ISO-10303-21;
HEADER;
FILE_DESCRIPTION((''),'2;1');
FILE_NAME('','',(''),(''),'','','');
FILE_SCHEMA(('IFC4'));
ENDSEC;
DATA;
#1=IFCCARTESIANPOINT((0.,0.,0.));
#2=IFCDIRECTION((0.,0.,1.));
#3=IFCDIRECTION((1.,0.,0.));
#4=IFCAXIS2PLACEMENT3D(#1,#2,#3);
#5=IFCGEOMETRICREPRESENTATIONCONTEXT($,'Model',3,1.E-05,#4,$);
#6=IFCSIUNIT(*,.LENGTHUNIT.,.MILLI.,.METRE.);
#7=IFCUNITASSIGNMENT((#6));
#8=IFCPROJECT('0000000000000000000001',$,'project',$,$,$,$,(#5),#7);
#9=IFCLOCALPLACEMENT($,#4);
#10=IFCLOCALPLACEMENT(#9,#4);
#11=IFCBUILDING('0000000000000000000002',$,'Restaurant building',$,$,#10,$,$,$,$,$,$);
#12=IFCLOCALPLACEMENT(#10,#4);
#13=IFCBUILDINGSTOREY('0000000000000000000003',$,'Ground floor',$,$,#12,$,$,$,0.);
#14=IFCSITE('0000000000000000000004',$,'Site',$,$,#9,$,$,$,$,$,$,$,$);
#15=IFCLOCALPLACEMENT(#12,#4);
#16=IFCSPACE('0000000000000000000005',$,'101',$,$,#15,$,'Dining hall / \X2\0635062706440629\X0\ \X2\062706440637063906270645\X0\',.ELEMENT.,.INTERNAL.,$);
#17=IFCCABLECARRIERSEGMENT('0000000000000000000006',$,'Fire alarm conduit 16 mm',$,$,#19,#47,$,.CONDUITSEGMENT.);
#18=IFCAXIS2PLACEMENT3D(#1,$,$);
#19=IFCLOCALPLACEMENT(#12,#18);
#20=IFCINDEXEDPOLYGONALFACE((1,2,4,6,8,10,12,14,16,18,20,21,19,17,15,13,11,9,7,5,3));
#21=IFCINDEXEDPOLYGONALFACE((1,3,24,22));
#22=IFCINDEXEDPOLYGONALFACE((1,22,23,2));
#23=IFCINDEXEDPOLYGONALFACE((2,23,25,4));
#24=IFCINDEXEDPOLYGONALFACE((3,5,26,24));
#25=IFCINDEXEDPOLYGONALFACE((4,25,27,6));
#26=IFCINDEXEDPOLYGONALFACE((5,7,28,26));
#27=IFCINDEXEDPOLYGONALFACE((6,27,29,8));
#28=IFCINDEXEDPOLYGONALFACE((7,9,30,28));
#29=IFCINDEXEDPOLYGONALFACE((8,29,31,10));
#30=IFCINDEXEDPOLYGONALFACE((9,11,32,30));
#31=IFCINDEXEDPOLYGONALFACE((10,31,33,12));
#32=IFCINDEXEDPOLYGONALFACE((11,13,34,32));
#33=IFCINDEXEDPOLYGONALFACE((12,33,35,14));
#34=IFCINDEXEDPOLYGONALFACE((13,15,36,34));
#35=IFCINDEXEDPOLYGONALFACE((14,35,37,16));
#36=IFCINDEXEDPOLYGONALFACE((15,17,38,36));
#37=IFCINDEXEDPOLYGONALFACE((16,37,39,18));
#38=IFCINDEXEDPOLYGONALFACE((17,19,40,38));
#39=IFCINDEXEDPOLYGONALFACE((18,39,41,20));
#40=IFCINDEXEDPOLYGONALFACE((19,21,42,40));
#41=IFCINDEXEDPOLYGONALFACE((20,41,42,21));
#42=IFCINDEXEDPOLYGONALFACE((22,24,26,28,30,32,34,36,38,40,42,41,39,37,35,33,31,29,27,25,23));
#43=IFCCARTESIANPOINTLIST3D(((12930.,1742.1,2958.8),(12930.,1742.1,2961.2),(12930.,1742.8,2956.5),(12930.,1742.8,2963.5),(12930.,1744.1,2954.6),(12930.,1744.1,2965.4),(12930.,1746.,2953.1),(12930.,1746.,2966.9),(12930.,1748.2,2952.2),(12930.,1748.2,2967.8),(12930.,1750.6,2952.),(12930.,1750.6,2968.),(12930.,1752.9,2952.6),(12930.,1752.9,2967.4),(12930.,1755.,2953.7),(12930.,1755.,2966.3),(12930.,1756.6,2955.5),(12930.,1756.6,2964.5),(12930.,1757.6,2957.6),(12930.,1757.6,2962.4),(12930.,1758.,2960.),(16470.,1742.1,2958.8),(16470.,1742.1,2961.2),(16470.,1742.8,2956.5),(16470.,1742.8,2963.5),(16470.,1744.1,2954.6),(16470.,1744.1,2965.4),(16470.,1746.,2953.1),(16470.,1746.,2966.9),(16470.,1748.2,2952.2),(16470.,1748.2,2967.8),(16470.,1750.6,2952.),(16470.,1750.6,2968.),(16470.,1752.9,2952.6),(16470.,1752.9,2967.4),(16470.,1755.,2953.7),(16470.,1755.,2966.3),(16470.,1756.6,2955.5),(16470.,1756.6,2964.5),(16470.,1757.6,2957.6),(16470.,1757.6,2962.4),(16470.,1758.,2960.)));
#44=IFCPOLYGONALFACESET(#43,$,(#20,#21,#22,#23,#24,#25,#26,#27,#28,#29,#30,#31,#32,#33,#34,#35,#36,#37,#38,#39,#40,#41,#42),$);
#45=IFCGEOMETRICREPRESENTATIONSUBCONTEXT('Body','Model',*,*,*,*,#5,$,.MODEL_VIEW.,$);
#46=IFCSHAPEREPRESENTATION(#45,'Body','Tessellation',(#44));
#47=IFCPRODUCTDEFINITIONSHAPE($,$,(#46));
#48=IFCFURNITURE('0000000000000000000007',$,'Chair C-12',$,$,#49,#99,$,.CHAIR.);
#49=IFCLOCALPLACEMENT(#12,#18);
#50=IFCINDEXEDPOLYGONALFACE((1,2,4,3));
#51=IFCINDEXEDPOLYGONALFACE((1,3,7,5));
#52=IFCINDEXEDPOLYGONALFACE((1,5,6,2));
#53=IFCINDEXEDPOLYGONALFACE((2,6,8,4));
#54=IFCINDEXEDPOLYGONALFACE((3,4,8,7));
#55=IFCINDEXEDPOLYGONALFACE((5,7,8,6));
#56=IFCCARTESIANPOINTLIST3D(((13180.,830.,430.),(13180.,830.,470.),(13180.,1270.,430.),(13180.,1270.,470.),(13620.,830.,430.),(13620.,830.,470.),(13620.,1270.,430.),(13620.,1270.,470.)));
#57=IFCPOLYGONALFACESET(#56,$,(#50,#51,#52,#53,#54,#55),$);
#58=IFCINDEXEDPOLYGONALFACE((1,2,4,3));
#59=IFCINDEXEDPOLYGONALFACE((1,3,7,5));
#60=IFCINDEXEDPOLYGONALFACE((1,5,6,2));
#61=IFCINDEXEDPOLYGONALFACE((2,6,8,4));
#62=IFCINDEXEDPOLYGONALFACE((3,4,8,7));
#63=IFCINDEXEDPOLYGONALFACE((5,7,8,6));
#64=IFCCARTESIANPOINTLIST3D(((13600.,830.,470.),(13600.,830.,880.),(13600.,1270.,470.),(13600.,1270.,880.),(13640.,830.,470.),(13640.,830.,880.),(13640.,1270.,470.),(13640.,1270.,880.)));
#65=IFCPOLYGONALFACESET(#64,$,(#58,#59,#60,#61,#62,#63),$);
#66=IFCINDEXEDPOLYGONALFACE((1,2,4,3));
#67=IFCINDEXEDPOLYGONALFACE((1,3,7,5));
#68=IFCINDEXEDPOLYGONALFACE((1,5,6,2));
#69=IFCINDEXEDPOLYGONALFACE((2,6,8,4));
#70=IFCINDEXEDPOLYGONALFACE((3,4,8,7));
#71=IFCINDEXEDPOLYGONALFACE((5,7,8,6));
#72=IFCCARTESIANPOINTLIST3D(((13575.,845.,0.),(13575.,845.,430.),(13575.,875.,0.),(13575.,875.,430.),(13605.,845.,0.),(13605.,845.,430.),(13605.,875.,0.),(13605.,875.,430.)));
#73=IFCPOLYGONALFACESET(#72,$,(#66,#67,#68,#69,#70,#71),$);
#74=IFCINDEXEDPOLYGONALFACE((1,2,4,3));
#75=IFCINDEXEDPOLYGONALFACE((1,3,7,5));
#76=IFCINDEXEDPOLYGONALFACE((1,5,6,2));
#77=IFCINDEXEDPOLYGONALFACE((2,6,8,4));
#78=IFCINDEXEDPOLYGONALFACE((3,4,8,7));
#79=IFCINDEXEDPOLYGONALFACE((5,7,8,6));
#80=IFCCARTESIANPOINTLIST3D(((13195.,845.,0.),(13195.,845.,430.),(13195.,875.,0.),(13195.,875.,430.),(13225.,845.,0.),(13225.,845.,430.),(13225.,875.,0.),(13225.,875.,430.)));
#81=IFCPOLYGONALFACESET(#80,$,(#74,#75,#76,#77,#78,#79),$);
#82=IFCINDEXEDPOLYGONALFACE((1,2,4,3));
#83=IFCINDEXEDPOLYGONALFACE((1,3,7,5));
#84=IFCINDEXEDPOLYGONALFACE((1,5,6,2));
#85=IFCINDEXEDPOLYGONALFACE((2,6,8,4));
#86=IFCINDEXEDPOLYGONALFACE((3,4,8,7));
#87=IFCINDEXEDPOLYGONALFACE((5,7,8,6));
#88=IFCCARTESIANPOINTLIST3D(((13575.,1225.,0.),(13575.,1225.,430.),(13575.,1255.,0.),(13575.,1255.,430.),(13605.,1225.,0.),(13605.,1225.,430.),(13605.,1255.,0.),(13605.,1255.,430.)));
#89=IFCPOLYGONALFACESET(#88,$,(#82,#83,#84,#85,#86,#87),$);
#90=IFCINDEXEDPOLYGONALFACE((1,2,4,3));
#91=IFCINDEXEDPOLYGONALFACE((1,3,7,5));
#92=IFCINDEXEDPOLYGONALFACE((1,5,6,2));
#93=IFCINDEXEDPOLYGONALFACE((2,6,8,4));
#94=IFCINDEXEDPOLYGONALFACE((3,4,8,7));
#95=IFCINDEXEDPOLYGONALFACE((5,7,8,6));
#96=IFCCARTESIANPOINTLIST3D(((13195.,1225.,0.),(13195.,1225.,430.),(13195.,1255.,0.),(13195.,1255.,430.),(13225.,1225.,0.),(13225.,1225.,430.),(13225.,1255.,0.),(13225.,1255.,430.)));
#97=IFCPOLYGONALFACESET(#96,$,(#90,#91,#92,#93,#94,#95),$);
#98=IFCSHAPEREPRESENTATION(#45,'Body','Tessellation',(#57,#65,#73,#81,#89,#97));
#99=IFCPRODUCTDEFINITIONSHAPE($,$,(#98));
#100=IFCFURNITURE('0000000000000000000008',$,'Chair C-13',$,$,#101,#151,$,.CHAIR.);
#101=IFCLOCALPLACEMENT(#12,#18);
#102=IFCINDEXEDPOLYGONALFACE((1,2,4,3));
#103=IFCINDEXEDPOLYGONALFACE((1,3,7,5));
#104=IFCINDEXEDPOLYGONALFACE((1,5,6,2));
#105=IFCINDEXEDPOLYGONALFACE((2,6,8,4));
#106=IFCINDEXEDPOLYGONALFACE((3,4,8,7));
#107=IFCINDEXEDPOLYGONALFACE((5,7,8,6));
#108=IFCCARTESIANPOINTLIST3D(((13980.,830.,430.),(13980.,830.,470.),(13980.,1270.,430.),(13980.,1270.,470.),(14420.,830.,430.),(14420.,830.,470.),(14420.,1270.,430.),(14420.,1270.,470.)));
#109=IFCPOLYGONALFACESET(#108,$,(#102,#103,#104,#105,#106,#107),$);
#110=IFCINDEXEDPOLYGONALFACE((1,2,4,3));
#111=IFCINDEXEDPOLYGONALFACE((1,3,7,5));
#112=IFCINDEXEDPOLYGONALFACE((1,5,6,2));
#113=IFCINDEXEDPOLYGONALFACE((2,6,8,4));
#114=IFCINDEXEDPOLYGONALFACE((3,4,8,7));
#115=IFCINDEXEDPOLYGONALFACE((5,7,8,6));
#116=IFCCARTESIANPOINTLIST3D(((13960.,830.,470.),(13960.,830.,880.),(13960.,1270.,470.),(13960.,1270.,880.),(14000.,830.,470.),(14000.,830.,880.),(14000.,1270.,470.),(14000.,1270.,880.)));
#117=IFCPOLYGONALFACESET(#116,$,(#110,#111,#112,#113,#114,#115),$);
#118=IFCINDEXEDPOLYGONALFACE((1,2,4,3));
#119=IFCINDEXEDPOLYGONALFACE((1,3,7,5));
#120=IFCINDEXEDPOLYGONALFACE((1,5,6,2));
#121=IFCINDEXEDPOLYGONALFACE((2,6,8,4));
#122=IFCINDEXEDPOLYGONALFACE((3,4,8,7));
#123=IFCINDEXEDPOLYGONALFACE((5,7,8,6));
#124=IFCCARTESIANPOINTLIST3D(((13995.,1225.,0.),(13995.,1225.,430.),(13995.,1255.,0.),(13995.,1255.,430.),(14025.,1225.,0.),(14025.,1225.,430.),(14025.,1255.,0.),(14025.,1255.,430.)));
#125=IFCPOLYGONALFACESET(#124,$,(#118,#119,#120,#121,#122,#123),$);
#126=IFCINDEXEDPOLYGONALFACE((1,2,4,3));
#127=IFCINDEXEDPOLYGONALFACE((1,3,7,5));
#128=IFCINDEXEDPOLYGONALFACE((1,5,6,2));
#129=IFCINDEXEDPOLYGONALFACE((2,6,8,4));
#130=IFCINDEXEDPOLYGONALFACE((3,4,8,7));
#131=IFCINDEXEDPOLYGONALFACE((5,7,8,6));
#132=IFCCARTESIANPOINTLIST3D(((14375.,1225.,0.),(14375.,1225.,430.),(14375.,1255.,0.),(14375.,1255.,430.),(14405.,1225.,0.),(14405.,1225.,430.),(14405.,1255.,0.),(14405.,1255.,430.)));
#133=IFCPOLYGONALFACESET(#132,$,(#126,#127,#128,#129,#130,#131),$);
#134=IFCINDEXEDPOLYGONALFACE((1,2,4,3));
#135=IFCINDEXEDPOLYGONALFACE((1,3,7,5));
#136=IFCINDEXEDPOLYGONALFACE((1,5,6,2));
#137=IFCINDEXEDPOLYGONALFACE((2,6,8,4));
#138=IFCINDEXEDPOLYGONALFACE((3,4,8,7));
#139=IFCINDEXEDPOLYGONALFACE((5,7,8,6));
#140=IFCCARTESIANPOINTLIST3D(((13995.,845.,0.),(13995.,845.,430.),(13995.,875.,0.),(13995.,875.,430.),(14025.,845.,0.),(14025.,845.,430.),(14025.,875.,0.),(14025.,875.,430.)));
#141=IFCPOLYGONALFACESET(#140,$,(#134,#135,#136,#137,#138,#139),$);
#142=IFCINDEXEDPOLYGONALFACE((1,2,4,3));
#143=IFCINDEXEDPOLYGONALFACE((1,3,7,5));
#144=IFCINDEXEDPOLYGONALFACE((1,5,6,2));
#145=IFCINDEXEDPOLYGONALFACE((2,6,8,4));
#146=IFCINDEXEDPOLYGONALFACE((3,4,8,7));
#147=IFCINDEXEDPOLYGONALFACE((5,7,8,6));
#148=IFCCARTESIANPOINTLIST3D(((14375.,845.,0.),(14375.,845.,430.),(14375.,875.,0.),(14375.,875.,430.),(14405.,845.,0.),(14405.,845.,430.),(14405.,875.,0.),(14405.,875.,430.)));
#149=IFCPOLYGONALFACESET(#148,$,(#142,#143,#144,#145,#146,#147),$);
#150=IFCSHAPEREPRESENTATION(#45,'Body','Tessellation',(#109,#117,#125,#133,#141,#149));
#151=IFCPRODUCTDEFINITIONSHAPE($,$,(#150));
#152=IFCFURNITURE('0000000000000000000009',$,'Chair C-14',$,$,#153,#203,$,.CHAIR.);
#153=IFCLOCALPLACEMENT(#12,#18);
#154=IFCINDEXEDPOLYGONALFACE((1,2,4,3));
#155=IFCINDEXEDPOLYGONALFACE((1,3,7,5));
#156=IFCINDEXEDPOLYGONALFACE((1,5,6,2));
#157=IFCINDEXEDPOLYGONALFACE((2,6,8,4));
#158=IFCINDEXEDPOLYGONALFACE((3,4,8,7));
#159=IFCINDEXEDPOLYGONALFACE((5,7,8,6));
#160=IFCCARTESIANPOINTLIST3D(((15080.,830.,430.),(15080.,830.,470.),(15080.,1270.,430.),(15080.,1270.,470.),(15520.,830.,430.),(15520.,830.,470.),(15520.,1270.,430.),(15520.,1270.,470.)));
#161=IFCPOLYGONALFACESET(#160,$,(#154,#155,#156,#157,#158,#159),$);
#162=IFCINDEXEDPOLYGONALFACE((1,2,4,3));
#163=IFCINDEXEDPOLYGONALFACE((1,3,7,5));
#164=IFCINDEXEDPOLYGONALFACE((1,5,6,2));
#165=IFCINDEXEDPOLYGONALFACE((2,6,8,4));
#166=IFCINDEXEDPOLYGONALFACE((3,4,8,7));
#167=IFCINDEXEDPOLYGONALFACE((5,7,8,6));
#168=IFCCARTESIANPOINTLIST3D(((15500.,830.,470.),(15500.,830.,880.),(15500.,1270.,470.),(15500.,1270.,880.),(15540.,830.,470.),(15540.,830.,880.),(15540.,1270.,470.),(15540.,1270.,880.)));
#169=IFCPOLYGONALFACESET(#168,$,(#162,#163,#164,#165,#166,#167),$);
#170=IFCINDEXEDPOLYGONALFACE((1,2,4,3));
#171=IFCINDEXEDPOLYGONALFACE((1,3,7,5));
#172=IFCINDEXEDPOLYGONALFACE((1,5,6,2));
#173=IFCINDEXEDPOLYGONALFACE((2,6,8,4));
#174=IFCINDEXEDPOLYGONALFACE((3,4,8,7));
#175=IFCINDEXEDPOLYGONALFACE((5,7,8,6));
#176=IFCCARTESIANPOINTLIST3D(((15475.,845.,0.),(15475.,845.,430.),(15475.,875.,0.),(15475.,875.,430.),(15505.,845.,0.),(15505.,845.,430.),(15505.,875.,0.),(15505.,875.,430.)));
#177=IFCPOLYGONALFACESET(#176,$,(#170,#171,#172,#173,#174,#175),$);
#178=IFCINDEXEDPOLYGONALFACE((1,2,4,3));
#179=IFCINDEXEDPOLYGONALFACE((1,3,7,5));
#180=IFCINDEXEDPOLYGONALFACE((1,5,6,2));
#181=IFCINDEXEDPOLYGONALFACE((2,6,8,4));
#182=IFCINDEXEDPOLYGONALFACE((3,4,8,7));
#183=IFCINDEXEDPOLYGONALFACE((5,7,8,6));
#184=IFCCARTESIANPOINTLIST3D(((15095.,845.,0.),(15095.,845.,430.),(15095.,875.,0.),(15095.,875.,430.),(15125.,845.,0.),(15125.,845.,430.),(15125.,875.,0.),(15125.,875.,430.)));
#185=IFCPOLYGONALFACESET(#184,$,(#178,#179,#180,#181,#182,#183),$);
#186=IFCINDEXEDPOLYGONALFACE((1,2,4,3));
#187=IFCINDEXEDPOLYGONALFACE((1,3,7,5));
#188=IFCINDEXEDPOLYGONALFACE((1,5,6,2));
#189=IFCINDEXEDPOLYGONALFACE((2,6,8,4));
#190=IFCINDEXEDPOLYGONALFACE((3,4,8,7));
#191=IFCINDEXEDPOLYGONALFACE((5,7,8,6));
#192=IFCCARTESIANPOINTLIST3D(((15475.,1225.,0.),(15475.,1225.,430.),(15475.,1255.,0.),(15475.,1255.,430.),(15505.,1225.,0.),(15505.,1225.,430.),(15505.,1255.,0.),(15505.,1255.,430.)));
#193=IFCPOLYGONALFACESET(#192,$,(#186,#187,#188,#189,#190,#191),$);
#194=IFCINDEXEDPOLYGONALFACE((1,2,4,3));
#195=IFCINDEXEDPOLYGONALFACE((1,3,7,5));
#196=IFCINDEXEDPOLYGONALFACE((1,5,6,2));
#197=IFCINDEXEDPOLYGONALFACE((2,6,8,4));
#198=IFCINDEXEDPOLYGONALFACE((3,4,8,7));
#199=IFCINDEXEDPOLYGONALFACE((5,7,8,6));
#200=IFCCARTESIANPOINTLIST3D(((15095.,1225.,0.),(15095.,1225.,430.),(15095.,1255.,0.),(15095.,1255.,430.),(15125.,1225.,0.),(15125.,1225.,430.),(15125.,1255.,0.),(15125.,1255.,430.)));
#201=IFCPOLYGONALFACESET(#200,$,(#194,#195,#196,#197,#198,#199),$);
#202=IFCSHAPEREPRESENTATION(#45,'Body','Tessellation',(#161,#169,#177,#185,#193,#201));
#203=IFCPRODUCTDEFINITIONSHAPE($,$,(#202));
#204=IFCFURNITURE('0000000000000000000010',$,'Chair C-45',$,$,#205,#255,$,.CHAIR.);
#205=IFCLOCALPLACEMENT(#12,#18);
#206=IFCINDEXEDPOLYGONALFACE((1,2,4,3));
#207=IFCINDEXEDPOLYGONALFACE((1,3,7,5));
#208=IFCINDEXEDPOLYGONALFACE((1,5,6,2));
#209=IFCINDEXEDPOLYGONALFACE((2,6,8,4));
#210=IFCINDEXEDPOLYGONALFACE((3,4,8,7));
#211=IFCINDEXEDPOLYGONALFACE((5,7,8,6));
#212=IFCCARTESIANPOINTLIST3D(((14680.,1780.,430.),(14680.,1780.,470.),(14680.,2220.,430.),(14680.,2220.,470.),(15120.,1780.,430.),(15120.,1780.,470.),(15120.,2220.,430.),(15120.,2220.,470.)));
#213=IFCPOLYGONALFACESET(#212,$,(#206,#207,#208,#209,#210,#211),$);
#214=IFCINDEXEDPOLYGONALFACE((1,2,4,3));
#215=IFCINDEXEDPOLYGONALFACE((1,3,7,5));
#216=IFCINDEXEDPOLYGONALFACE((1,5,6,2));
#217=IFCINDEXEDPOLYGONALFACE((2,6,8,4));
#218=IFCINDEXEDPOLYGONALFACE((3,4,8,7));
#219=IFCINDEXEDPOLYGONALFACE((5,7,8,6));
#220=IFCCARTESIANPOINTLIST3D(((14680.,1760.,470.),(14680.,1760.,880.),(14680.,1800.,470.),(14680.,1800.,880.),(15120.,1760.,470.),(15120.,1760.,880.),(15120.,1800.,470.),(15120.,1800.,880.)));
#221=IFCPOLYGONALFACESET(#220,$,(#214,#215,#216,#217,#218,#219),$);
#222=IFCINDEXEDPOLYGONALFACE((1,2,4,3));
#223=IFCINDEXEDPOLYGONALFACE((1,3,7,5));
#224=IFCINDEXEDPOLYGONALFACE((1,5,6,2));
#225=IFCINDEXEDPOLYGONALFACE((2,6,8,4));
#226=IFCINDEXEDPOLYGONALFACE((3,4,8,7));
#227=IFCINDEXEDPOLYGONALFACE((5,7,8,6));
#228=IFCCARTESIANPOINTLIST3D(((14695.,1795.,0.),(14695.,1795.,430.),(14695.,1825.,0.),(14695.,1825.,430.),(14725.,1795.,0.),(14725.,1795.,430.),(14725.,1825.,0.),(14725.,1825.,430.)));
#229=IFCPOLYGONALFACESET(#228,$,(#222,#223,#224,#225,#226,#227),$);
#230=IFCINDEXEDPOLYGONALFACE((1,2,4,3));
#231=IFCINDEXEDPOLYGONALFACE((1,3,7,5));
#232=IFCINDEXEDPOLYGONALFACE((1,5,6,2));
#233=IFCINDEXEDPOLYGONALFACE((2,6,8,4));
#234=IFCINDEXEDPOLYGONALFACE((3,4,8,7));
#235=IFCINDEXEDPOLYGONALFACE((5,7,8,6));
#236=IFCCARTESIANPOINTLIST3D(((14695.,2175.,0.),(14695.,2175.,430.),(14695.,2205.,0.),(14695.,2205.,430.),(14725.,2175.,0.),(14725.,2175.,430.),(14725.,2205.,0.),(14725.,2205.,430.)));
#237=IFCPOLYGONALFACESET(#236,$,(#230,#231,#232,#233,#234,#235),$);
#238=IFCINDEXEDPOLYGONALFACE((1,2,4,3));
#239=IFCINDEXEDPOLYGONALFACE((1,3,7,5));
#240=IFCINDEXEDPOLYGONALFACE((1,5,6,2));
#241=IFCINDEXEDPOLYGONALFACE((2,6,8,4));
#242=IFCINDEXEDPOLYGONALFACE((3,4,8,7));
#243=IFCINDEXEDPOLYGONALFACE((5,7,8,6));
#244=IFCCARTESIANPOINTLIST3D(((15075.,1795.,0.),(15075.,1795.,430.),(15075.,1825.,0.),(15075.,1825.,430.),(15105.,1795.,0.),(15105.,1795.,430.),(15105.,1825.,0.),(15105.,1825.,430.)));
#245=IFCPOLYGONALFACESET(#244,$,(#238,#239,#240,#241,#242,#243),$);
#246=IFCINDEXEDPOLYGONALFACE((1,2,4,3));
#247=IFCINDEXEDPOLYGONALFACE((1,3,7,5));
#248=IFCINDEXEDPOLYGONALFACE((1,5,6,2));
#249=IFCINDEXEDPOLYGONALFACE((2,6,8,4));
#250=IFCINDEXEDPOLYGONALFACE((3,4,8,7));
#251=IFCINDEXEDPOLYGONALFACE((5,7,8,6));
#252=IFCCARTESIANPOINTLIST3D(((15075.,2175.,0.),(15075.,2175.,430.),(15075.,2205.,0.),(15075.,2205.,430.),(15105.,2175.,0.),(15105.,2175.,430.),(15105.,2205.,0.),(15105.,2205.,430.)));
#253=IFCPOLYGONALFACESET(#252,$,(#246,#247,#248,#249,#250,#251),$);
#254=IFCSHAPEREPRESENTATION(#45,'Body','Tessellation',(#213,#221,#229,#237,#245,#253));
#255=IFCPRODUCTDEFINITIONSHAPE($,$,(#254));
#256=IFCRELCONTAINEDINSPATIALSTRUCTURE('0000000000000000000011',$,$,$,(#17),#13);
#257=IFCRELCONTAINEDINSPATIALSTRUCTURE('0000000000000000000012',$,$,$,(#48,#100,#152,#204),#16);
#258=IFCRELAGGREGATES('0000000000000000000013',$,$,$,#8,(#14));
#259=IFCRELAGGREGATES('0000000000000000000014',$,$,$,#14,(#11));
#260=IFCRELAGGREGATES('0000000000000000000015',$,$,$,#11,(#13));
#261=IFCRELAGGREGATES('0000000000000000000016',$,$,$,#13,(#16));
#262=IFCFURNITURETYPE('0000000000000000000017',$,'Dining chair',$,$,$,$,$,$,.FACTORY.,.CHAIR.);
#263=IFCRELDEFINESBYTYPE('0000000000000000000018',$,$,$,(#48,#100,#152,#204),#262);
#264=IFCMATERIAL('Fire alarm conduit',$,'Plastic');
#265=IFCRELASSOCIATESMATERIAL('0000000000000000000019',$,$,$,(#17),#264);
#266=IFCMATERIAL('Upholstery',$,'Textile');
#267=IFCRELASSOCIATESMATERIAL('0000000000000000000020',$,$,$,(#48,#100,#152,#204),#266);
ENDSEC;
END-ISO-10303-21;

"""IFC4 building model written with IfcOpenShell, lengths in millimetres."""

from ifc_helpers import new_model, si_unit, frame, origin, origin_with_axes, origin_2d, place, context, subcontext, project, spatial, rectangle, circle, extrude, source, transform, mapped, material, type_object, type_shapes, element, save


model = new_model("IFC4")

# Units and contexts
model_context = context("Model", 3, precision=1e-05, world=origin_with_axes())
body_context = subcontext(model_context, "Body", "Model", "MODEL_VIEW")
ifc_project = project(units=[si_unit("LENGTHUNIT", "METRE", prefix="MILLI")], contexts=[model_context])

# Site, building, storey
site_placement = place(None, origin_with_axes())
site = spatial("IfcSite", under=ifc_project, at=site_placement, Name="Site")
building_placement = place(site_placement, origin_with_axes())
building = spatial("IfcBuilding", under=site, at=building_placement, Name="Restaurant building")
storey_placement = place(building_placement, origin_with_axes())
storey = spatial("IfcBuildingStorey", under=building, at=storey_placement, Name="Ground floor", Elevation=0.0)

# Shared definitions
space_placement = place(storey_placement, origin_with_axes())
space = spatial("IfcSpace", under=storey, at=space_placement, Name="101", LongName="Dining hall / صالة الطعام", CompositionType="ELEMENT", PredefinedType="INTERNAL")

# Cable carrier segment
ifc_material_1 = material(Name="Fire alarm conduit", Category="Plastic")
cable_carrier_segment_1_placement = place(storey_placement, frame((12930.0, 1750.0, 2960.0)))
element("IfcCableCarrierSegment", 1, at=cable_carrier_segment_1_placement, inside=storey, material=ifc_material_1, Name="Fire alarm conduit 16 mm", PredefinedType="CONDUITSEGMENT", context=body_context, shape_type="SweptSolid", body=[
    extrude(circle(Radius=8.0, at=origin_2d()), frame((0.0, 0.0, 0.0), z_axis=(1.0, 0.0, 0.0), x_axis=(0.0, 1.0, 0.0)), (0.0, 0.0, 1.0), 3540.0),
])

# Furniture
ifc_material_2 = material(Name="Upholstery", Category="Textile")
furniture_type_1 = type_object("IfcFurnitureType", Name="Dining chair", AssemblyPlace="FACTORY", PredefinedType="CHAIR")
shared_shape_1 = source(origin(), body_context, "Body", "SweptSolid", [
    extrude(rectangle(XDim=440.0, YDim=440.0, at=origin_2d()), frame((0.0, 0.0, 430.0)), (0.0, 0.0, 1.0), 40.0),
    extrude(rectangle(XDim=440.0, YDim=40.0, at=origin_2d()), frame((0.0, -220.0, 470.0)), (0.0, 0.0, 1.0), 410.0),
    extrude(rectangle(XDim=30.0, YDim=30.0, at=origin_2d()), frame((-190.0, -190.0, 0.0)), (0.0, 0.0, 1.0), 430.0),
    extrude(rectangle(XDim=30.0, YDim=30.0, at=origin_2d()), frame((-190.0, 190.0, 0.0)), (0.0, 0.0, 1.0), 430.0),
    extrude(rectangle(XDim=30.0, YDim=30.0, at=origin_2d()), frame((190.0, -190.0, 0.0)), (0.0, 0.0, 1.0), 430.0),
    extrude(rectangle(XDim=30.0, YDim=30.0, at=origin_2d()), frame((190.0, 190.0, 0.0)), (0.0, 0.0, 1.0), 430.0),
])
type_shapes(furniture_type_1, [shared_shape_1])
for number, where, z_axis, x_axis, name in (
    (2, (13400.0, 1050.0, 0.0), (0.0, 0.0, 1.0), (0.0, 1.0, 0.0), "Chair C-12"),
    (3, (14200.0, 1050.0, 0.0), (0.0, 0.0, 1.0), (0.0, -1.0, 0.0), "Chair C-13"),
    (4, (15300.0, 1050.0, 0.0), (0.0, 0.0, 1.0), (0.0, 1.0, 0.0), "Chair C-14"),
):
    element("IfcFurniture", number, at=place(storey_placement, frame(where, z_axis=z_axis, x_axis=x_axis)), inside=space, type_object=furniture_type_1, material=ifc_material_2, Name=name, PredefinedType="CHAIR", context=body_context, shape_type="MappedRepresentation", body=[
        mapped(shared_shape_1, transform((0.0, 0.0, 0.0))),
    ])
furniture_1_placement = place(storey_placement, frame((14900.0, 2000.0, 0.0)))
element("IfcFurniture", 5, at=furniture_1_placement, inside=space, type_object=furniture_type_1, material=ifc_material_2, Name="Chair C-45", PredefinedType="CHAIR", context=body_context, shape_type="MappedRepresentation", body=[
    mapped(shared_shape_1, transform((0.0, 0.0, 0.0))),
])

save(model, "model.ifc")
